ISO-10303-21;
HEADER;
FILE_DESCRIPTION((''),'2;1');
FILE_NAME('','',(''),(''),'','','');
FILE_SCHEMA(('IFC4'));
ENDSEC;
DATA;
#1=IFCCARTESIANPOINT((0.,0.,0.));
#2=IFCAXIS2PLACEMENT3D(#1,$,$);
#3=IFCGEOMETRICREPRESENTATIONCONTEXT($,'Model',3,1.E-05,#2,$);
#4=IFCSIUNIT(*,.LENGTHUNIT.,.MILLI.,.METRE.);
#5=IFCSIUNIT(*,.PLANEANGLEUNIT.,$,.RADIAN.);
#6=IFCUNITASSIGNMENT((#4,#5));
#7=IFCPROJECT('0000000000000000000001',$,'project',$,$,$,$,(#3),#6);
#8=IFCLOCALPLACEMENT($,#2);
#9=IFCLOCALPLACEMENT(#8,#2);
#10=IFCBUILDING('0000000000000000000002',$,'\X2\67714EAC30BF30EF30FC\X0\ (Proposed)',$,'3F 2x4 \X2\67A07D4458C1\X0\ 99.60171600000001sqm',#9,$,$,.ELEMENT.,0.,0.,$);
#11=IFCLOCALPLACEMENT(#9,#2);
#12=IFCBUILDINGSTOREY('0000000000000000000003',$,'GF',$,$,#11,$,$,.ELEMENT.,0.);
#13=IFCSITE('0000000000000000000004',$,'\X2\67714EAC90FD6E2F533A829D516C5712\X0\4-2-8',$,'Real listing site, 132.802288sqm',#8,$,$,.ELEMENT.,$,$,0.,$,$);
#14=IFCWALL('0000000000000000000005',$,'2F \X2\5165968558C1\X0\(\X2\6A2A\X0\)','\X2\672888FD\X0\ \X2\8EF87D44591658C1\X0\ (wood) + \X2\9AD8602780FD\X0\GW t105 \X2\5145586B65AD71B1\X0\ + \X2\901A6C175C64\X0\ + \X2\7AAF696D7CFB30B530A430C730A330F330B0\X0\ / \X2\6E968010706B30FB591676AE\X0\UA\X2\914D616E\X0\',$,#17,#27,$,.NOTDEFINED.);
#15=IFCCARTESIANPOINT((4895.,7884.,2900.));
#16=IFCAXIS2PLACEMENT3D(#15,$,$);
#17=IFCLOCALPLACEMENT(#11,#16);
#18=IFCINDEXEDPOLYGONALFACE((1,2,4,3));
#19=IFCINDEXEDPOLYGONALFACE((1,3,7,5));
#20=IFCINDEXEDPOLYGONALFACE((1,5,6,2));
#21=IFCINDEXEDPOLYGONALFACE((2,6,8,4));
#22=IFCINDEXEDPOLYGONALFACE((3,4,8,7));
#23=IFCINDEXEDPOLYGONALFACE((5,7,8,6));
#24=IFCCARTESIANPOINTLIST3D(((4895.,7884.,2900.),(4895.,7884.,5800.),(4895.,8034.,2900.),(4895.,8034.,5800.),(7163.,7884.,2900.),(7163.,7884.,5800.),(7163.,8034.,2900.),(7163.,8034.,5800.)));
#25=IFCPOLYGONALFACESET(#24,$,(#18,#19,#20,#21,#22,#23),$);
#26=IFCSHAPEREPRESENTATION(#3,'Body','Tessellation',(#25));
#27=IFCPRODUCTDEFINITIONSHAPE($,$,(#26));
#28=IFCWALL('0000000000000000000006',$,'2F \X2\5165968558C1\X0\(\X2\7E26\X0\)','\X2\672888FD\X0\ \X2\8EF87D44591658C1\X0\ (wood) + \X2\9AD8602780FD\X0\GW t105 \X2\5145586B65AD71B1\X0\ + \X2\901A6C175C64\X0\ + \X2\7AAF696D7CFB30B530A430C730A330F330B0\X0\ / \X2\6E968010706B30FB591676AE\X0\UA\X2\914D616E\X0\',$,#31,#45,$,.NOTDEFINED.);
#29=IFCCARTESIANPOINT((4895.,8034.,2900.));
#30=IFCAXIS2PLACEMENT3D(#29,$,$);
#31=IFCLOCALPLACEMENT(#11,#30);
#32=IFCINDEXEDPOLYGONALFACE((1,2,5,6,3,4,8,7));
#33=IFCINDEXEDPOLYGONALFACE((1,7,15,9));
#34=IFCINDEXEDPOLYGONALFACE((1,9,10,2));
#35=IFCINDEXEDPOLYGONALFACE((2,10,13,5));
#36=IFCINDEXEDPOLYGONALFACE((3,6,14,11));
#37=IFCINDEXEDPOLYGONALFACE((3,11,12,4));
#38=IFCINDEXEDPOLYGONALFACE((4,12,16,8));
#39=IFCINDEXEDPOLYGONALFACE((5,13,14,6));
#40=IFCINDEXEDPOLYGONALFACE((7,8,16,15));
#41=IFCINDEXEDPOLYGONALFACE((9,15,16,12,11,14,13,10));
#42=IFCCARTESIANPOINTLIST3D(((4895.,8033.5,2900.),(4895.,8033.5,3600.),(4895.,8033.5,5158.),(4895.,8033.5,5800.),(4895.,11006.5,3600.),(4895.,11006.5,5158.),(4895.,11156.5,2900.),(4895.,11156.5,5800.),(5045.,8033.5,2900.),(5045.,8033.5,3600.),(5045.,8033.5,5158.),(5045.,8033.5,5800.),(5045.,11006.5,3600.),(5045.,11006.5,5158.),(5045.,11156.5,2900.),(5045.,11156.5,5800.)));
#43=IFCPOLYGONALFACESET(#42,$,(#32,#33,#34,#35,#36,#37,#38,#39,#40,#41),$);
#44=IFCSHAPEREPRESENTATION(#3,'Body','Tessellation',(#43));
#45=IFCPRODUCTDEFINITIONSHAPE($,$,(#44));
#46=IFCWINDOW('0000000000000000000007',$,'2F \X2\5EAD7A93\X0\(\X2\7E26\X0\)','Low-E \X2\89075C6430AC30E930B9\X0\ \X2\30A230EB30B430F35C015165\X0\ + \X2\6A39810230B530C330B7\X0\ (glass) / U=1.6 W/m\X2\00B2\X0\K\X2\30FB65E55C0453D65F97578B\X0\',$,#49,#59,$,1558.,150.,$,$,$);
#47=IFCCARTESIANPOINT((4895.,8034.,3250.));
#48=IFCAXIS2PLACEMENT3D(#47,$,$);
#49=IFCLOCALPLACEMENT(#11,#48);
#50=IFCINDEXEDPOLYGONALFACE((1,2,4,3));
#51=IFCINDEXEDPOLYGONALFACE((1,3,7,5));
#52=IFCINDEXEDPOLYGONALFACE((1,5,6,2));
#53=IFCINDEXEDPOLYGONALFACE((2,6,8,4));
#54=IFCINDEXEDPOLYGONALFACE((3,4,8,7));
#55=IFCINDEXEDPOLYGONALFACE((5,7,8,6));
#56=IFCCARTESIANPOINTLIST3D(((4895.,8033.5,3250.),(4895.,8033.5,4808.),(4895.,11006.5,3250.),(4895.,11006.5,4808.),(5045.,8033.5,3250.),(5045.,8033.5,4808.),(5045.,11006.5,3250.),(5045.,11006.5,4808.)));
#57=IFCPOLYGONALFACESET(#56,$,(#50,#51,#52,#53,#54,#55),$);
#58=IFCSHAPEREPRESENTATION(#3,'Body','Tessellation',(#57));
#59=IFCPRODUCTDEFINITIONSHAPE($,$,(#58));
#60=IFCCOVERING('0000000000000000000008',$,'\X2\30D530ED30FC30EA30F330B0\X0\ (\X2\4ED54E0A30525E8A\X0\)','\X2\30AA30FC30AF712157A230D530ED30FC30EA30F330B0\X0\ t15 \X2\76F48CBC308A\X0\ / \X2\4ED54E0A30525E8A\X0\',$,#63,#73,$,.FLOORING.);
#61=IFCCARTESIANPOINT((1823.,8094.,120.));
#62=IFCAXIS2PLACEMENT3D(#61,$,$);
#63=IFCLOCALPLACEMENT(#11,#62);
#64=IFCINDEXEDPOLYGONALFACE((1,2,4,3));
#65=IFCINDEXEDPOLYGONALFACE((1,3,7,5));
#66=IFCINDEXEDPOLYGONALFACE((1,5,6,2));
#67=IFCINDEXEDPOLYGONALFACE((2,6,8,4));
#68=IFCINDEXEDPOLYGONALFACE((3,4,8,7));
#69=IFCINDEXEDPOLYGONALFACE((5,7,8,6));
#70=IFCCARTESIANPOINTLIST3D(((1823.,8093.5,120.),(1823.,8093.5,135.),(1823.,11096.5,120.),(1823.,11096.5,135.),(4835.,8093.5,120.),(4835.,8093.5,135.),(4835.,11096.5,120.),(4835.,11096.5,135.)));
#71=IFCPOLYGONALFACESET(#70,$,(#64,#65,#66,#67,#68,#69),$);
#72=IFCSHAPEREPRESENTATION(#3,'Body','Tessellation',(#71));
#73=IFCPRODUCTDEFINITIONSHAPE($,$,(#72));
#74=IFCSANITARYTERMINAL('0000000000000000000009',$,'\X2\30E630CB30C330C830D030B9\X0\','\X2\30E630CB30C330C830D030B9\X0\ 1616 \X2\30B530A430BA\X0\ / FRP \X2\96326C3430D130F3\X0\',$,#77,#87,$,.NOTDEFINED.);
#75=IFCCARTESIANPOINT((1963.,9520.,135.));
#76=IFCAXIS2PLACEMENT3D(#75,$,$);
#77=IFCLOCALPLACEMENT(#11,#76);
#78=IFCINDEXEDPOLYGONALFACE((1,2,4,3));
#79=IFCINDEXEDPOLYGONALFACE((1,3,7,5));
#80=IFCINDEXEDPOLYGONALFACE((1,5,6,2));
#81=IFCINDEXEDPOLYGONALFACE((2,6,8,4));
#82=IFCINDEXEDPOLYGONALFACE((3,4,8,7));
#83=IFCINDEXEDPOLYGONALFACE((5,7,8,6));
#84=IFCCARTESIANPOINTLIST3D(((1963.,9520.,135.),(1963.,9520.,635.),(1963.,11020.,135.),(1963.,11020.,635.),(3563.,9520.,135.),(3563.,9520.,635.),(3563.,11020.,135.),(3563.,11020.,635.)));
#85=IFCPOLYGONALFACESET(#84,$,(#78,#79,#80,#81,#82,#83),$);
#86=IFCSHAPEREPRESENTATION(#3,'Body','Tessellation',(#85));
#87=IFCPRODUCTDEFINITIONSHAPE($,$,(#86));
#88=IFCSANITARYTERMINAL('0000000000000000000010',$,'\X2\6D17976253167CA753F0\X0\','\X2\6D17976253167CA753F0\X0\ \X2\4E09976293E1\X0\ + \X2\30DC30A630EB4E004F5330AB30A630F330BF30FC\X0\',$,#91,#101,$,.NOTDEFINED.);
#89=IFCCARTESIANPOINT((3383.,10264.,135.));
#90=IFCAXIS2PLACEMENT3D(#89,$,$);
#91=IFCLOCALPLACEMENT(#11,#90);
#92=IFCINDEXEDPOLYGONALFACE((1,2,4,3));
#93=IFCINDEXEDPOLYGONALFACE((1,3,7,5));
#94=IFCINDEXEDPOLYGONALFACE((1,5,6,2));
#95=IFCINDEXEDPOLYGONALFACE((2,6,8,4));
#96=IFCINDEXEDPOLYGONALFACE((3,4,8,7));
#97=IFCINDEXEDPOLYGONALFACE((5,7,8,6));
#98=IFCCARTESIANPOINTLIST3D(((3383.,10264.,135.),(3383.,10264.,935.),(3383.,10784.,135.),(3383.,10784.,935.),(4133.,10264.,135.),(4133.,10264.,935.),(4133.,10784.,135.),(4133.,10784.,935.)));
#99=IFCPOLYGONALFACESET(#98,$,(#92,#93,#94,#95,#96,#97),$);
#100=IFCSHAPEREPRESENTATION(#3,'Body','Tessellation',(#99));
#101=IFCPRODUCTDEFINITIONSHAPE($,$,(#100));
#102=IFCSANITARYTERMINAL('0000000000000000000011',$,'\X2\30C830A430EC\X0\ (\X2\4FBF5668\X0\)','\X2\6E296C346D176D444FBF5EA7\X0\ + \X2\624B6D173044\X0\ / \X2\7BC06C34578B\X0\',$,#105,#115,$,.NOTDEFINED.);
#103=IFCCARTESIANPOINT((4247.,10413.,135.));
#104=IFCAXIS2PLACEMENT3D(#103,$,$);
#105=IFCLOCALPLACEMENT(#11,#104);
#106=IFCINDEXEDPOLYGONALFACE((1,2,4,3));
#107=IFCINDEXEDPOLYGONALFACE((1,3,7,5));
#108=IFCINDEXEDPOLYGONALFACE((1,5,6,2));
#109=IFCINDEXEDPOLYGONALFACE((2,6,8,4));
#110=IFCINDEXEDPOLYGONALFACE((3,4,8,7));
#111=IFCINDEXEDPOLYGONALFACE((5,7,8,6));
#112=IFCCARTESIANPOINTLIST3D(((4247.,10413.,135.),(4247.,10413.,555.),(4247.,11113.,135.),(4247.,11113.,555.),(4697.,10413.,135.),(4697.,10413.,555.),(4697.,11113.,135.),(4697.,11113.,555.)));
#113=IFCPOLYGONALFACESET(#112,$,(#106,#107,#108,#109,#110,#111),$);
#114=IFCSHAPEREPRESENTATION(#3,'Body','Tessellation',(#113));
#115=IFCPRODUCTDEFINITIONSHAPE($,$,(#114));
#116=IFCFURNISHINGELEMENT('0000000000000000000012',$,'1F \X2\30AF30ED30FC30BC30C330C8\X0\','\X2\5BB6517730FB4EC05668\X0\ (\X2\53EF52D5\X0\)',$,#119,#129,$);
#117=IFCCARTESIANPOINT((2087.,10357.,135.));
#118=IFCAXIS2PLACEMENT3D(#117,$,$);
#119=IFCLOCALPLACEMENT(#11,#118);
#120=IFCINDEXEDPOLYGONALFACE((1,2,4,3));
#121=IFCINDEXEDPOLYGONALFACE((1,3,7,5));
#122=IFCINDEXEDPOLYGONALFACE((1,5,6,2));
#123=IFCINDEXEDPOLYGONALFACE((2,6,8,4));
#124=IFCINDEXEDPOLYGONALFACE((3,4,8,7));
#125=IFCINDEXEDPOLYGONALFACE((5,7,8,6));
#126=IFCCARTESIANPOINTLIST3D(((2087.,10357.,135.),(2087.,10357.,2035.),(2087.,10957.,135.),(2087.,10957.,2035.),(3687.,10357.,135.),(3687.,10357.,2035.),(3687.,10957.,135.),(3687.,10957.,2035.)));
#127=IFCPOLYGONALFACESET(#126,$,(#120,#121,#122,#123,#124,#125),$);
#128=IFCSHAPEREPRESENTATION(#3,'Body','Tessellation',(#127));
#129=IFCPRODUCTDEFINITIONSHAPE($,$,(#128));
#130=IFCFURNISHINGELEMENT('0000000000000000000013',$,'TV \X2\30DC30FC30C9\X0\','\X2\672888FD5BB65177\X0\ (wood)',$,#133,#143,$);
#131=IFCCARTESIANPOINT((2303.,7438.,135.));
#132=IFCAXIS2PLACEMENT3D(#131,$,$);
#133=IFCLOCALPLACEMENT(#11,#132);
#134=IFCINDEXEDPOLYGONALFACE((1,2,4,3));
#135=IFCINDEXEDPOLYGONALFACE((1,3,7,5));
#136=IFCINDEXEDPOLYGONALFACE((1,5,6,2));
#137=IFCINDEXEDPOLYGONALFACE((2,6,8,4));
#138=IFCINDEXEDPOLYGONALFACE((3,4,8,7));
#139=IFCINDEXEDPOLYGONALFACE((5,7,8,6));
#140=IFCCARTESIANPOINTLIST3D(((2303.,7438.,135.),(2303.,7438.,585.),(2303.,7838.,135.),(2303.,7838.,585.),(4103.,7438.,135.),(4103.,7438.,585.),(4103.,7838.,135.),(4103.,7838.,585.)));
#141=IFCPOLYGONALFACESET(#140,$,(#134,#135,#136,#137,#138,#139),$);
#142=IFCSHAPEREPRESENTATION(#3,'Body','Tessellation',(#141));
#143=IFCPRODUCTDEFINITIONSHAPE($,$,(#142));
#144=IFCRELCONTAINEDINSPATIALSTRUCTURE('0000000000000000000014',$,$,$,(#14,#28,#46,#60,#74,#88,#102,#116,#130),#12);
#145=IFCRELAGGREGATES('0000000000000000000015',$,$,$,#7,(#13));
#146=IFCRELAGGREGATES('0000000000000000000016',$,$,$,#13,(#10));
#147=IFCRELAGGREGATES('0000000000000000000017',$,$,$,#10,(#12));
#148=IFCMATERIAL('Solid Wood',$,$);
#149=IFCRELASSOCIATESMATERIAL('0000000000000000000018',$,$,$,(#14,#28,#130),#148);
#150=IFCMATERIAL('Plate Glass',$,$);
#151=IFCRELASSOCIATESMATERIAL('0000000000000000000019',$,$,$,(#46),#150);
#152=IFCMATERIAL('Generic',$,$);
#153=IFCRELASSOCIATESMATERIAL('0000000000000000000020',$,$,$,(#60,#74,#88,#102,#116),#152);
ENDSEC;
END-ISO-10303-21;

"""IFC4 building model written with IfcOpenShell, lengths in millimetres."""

from ifc_helpers import new_model, si_unit, frame, frame_2d, origin, place, context, project, spatial, rectangle, extrude, material, element, fill, save


model = new_model("IFC4")

# Units and contexts
model_context = context("Model", 3, precision=1e-05, world=origin())
ifc_project = project(units=[si_unit("LENGTHUNIT", "METRE", prefix="MILLI"), si_unit("PLANEANGLEUNIT", "RADIAN")], contexts=[model_context])

# Site, building, storey
site_placement = place(None, origin())
site = spatial("IfcSite", under=ifc_project, at=site_placement, Name="東京都港区芝公園4-2-8", ObjectType="Real listing site, 132.802288sqm", CompositionType="ELEMENT", RefElevation=0.0)
building_placement = place(site_placement, origin())
building = spatial("IfcBuilding", under=site, at=building_placement, Name="東京タワー (Proposed)", ObjectType="3F 2x4 枠組壁 99.60171600000001sqm", CompositionType="ELEMENT", ElevationOfRefHeight=0.0, ElevationOfTerrain=0.0)
storey_placement = place(building_placement, origin())
storey = spatial("IfcBuildingStorey", under=building, at=storey_placement, Name="GF", CompositionType="ELEMENT", Elevation=0.0)

# Shared definitions
ifc_material_1 = material(Name="Solid Wood")

# Shared definitions
ifc_material_2 = material(Name="Plate Glass")

# Wall
wall_1_placement = place(storey_placement, frame((4895.0, 7884.0, 2900.0)))
element("IfcWall", 1, at=wall_1_placement, inside=storey, material=ifc_material_1, Name="2F 入隅壁(横)", Description="木製 軸組外壁 (wood) + 高性能GW t105 充填断熱 + 通気層 + 窯業系サイディング / 準耐火・外皮UA配慮", PredefinedType="NOTDEFINED", context=model_context, shape_type="SweptSolid", body=[
    extrude(rectangle(XDim=2268.0, YDim=150.0, at=frame_2d((1134.0, 75.0))), frame((4895.0, 7884.0, 2900.0)), (0.0, 0.0, 1.0), 2900.0),
])

# Wall, opening, window
wall_2_placement = place(storey_placement, frame((4895.0, 8034.0, 2900.0)))
wall_2 = element("IfcWall", 2, at=wall_2_placement, inside=storey, material=ifc_material_1, Name="2F 入隅壁(縦)", Description="木製 軸組外壁 (wood) + 高性能GW t105 充填断熱 + 通気層 + 窯業系サイディング / 準耐火・外皮UA配慮", PredefinedType="NOTDEFINED", context=model_context, shape_type="SweptSolid", body=[
    extrude(rectangle(XDim=150.0, YDim=3123.0, at=frame_2d((75.0, 1561.0))), frame((4895.0, 8034.0, 2900.0)), (0.0, 0.0, 1.0), 2900.0),
])
opening_1_placement = place(storey_placement, frame((4895.0, 8034.0, 3250.0)))
opening_1 = element("IfcOpeningElement", 3, at=opening_1_placement, cuts=wall_2, PredefinedType="NOTDEFINED", context=model_context, shape_type="SweptSolid", body=[
    extrude(rectangle(XDim=150.0, YDim=2973.0, at=frame_2d((75.0, 1486.0))), frame((4895.0, 8034.0, 3250.0)), (0.0, 0.0, 1.0), 1558.0),
])
window_1_placement = place(storey_placement, frame((4895.0, 8034.0, 3250.0)))
window_1 = element("IfcWindow", 4, at=window_1_placement, inside=storey, material=ifc_material_2, Name="2F 庭窓(縦)", Description="Low-E 複層ガラス アルゴン封入 + 樹脂サッシ (glass) / U=1.6 W/m²K・日射取得型", OverallHeight=1558.0, OverallWidth=150.0, context=model_context, shape_type="SweptSolid", body=[
    extrude(rectangle(XDim=150.0, YDim=2973.0, at=frame_2d((75.0, 1486.0))), frame((4895.0, 8034.0, 3250.0)), (0.0, 0.0, 1.0), 1558.0),
])
fill(opening_1, window_1)

# Covering
ifc_material_3 = material(Name="Generic")
covering_placement = place(storey_placement, frame((1823.0, 8094.0, 120.0)))
element("IfcCovering", 5, at=covering_placement, inside=storey, material=ifc_material_3, Name="フローリング (仕上げ床)", Description="オーク無垢フローリング t15 直貼り / 仕上げ床", PredefinedType="FLOORING", context=model_context, shape_type="SweptSolid", body=[
    extrude(rectangle(XDim=3012.0, YDim=3003.0, at=frame_2d((1506.0, 1501.0))), frame((1823.0, 8094.0, 120.0)), (0.0, 0.0, 1.0), 15.0),
])

# Sanitary terminals
sanitary_terminal_1_placement = place(storey_placement, frame((1963.0, 9520.0, 135.0)))
element("IfcSanitaryTerminal", 6, at=sanitary_terminal_1_placement, inside=storey, material=ifc_material_3, Name="ユニットバス", Description="ユニットバス 1616 サイズ / FRP 防水パン", PredefinedType="NOTDEFINED", context=model_context, shape_type="SweptSolid", body=[
    extrude(rectangle(XDim=1600.0, YDim=1500.0, at=frame_2d((800.0, 750.0))), frame((1963.0, 9520.0, 135.0)), (0.0, 0.0, 1.0), 500.0),
])
sanitary_terminal_2_placement = place(storey_placement, frame((3383.0, 10264.0, 135.0)))
element("IfcSanitaryTerminal", 7, at=sanitary_terminal_2_placement, inside=storey, material=ifc_material_3, Name="洗面化粧台", Description="洗面化粧台 三面鏡 + ボウル一体カウンター", PredefinedType="NOTDEFINED", context=model_context, shape_type="SweptSolid", body=[
    extrude(rectangle(XDim=750.0, YDim=520.0, at=frame_2d((375.0, 260.0))), frame((3383.0, 10264.0, 135.0)), (0.0, 0.0, 1.0), 800.0),
])
sanitary_terminal_3_placement = place(storey_placement, frame((4247.0, 10413.0, 135.0)))
element("IfcSanitaryTerminal", 8, at=sanitary_terminal_3_placement, inside=storey, material=ifc_material_3, Name="トイレ (便器)", Description="温水洗浄便座 + 手洗い / 節水型", PredefinedType="NOTDEFINED", context=model_context, shape_type="SweptSolid", body=[
    extrude(rectangle(XDim=450.0, YDim=700.0, at=frame_2d((225.0, 350.0))), frame((4247.0, 10413.0, 135.0)), (0.0, 0.0, 1.0), 420.0),
])

# Furnishing elements
furnishing_1_placement = place(storey_placement, frame((2087.0, 10357.0, 135.0)))
element("IfcFurnishingElement", 9, at=furnishing_1_placement, inside=storey, material=ifc_material_3, Name="1F クローゼット", Description="家具・什器 (可動)", context=model_context, shape_type="SweptSolid", body=[
    extrude(rectangle(XDim=1600.0, YDim=600.0, at=frame_2d((800.0, 300.0))), frame((2087.0, 10357.0, 135.0)), (0.0, 0.0, 1.0), 1900.0),
])
furnishing_2_placement = place(storey_placement, frame((2303.0, 7438.0, 135.0)))
element("IfcFurnishingElement", 10, at=furnishing_2_placement, inside=storey, material=ifc_material_1, Name="TV ボード", Description="木製家具 (wood)", context=model_context, shape_type="SweptSolid", body=[
    extrude(rectangle(XDim=1800.0, YDim=400.0, at=frame_2d((900.0, 200.0))), frame((2303.0, 7438.0, 135.0)), (0.0, 0.0, 1.0), 450.0),
])

save(model, "model.ifc")
